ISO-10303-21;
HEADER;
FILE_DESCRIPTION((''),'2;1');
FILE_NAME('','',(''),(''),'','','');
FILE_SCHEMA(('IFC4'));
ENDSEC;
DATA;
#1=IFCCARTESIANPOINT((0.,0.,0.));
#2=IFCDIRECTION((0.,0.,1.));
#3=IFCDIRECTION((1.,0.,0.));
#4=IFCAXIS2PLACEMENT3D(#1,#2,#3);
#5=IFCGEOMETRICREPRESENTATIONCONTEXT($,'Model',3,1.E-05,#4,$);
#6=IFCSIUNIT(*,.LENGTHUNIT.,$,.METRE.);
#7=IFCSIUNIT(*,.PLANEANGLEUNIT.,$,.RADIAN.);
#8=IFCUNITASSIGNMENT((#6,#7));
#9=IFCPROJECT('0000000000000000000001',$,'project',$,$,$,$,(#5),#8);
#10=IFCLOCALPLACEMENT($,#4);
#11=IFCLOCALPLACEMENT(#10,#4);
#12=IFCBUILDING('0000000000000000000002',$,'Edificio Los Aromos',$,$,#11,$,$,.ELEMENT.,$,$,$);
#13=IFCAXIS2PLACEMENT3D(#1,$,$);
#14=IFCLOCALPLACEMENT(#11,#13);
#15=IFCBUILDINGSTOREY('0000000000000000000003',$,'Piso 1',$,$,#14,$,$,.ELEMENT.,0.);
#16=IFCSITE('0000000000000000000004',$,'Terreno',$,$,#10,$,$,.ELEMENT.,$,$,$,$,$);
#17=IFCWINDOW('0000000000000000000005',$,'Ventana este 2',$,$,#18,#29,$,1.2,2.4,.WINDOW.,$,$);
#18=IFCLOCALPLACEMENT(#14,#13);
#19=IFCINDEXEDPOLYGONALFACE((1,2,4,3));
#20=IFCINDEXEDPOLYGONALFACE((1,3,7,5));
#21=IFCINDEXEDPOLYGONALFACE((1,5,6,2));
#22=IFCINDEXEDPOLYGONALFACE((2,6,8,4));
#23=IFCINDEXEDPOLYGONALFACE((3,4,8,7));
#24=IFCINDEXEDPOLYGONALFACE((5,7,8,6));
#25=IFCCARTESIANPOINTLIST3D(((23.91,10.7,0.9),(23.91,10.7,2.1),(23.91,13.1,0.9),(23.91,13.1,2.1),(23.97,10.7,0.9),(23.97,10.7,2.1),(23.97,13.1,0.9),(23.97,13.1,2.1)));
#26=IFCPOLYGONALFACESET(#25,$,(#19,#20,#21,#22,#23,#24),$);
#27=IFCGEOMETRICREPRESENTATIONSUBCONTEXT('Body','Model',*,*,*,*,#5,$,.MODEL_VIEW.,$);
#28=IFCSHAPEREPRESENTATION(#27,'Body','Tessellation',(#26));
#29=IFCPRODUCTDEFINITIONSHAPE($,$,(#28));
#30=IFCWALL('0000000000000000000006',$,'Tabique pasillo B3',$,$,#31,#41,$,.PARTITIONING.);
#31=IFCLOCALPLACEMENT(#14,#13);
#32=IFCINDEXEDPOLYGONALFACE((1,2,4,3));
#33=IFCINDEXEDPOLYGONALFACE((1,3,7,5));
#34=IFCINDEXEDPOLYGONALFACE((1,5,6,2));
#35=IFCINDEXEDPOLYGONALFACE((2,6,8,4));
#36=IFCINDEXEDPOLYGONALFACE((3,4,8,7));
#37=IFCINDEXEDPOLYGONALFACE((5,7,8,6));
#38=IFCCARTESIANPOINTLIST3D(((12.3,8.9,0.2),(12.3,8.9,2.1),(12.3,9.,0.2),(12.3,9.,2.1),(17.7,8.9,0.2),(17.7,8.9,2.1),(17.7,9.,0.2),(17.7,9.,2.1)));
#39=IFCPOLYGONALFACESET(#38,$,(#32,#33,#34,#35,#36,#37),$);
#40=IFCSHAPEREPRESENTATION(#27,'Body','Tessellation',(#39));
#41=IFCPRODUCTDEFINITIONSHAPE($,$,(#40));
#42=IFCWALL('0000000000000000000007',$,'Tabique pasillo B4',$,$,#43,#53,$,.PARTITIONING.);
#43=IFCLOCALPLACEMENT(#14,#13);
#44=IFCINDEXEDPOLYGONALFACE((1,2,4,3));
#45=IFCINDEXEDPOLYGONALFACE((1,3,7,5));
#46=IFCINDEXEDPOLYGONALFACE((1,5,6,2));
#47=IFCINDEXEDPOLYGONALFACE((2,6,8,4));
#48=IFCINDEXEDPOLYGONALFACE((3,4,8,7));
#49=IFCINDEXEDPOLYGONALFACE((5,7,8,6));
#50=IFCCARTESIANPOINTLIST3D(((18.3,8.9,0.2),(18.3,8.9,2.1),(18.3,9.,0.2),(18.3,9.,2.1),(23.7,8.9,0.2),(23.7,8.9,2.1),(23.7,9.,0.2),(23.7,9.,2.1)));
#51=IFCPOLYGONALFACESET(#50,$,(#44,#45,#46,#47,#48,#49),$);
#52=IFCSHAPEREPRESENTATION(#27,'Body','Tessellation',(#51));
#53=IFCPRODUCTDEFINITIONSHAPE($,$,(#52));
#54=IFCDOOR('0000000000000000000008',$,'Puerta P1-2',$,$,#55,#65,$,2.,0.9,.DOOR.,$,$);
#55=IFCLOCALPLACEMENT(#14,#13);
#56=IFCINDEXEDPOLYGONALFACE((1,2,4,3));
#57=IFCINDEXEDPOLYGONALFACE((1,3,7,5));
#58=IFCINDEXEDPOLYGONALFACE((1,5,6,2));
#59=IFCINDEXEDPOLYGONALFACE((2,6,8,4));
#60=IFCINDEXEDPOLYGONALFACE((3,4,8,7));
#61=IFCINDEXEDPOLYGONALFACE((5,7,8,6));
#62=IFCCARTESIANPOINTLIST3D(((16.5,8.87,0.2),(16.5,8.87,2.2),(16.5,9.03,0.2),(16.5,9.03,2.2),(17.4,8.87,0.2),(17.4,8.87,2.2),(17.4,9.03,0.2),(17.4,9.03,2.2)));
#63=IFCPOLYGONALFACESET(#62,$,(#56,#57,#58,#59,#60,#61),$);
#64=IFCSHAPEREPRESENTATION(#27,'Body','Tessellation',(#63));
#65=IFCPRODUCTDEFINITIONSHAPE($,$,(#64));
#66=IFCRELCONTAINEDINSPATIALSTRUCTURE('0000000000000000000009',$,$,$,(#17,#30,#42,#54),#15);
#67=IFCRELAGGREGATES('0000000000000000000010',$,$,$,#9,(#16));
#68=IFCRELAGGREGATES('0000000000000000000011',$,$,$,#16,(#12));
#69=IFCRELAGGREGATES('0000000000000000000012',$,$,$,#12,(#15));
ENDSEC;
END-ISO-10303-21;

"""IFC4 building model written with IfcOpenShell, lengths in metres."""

from ifc_helpers import new_model, si_unit, frame, frame_2d, origin, origin_with_axes, place, context, subcontext, project, spatial, rectangle, extrude, element, save


model = new_model("IFC4")

# Units and contexts
model_context = context("Model", 3, precision=1e-05, world=origin_with_axes())
body_context = subcontext(model_context, "Body", "Model", "MODEL_VIEW")
ifc_project = project(units=[si_unit("LENGTHUNIT", "METRE"), si_unit("PLANEANGLEUNIT", "RADIAN")], contexts=[model_context])

# Site, building, storey
site_placement = place(None, origin_with_axes())
site = spatial("IfcSite", under=ifc_project, at=site_placement, Name="Terreno", CompositionType="ELEMENT")
building_placement = place(site_placement, origin_with_axes())
building = spatial("IfcBuilding", under=site, at=building_placement, Name="Edificio Los Aromos", CompositionType="ELEMENT")
storey_placement = place(building_placement, origin())
storey = spatial("IfcBuildingStorey", under=building, at=storey_placement, Name="Piso 1", CompositionType="ELEMENT", Elevation=0.0)

# Window
window_1_placement = place(storey_placement, frame((23.91, 10.7, 0.9)))
element("IfcWindow", 1, at=window_1_placement, inside=storey, Name="Ventana este 2", OverallHeight=1.2, OverallWidth=2.4, PredefinedType="WINDOW", context=body_context, shape_type="SweptSolid", body=[
    extrude(rectangle(XDim=0.06, YDim=2.4, at=frame_2d((0.03, 1.2))), origin_with_axes(), (0.0, 0.0, 1.0), 1.2),
])

# Walls
for number, where, name in (
    (2, (12.3, 8.9, 0.2), "Tabique pasillo B3"),
    (3, (18.3, 8.9, 0.2), "Tabique pasillo B4"),
):
    element("IfcWall", number, at=place(storey_placement, frame(where)), inside=storey, Name=name, PredefinedType="PARTITIONING", context=body_context, shape_type="SweptSolid", body=[
        extrude(rectangle(XDim=5.4, YDim=0.1, at=frame_2d((2.7, 0.05))), origin_with_axes(), (0.0, 0.0, 1.0), 1.9),
    ])

# Door
door_placement = place(storey_placement, frame((16.5, 8.87, 0.2)))
element("IfcDoor", 4, at=door_placement, inside=storey, Name="Puerta P1-2", OverallHeight=2.0, OverallWidth=0.9, PredefinedType="DOOR", context=body_context, shape_type="SweptSolid", body=[
    extrude(rectangle(XDim=0.9, YDim=0.16, at=frame_2d((0.45, 0.08))), origin_with_axes(), (0.0, 0.0, 1.0), 2.0),
])

save(model, "model.ifc")
